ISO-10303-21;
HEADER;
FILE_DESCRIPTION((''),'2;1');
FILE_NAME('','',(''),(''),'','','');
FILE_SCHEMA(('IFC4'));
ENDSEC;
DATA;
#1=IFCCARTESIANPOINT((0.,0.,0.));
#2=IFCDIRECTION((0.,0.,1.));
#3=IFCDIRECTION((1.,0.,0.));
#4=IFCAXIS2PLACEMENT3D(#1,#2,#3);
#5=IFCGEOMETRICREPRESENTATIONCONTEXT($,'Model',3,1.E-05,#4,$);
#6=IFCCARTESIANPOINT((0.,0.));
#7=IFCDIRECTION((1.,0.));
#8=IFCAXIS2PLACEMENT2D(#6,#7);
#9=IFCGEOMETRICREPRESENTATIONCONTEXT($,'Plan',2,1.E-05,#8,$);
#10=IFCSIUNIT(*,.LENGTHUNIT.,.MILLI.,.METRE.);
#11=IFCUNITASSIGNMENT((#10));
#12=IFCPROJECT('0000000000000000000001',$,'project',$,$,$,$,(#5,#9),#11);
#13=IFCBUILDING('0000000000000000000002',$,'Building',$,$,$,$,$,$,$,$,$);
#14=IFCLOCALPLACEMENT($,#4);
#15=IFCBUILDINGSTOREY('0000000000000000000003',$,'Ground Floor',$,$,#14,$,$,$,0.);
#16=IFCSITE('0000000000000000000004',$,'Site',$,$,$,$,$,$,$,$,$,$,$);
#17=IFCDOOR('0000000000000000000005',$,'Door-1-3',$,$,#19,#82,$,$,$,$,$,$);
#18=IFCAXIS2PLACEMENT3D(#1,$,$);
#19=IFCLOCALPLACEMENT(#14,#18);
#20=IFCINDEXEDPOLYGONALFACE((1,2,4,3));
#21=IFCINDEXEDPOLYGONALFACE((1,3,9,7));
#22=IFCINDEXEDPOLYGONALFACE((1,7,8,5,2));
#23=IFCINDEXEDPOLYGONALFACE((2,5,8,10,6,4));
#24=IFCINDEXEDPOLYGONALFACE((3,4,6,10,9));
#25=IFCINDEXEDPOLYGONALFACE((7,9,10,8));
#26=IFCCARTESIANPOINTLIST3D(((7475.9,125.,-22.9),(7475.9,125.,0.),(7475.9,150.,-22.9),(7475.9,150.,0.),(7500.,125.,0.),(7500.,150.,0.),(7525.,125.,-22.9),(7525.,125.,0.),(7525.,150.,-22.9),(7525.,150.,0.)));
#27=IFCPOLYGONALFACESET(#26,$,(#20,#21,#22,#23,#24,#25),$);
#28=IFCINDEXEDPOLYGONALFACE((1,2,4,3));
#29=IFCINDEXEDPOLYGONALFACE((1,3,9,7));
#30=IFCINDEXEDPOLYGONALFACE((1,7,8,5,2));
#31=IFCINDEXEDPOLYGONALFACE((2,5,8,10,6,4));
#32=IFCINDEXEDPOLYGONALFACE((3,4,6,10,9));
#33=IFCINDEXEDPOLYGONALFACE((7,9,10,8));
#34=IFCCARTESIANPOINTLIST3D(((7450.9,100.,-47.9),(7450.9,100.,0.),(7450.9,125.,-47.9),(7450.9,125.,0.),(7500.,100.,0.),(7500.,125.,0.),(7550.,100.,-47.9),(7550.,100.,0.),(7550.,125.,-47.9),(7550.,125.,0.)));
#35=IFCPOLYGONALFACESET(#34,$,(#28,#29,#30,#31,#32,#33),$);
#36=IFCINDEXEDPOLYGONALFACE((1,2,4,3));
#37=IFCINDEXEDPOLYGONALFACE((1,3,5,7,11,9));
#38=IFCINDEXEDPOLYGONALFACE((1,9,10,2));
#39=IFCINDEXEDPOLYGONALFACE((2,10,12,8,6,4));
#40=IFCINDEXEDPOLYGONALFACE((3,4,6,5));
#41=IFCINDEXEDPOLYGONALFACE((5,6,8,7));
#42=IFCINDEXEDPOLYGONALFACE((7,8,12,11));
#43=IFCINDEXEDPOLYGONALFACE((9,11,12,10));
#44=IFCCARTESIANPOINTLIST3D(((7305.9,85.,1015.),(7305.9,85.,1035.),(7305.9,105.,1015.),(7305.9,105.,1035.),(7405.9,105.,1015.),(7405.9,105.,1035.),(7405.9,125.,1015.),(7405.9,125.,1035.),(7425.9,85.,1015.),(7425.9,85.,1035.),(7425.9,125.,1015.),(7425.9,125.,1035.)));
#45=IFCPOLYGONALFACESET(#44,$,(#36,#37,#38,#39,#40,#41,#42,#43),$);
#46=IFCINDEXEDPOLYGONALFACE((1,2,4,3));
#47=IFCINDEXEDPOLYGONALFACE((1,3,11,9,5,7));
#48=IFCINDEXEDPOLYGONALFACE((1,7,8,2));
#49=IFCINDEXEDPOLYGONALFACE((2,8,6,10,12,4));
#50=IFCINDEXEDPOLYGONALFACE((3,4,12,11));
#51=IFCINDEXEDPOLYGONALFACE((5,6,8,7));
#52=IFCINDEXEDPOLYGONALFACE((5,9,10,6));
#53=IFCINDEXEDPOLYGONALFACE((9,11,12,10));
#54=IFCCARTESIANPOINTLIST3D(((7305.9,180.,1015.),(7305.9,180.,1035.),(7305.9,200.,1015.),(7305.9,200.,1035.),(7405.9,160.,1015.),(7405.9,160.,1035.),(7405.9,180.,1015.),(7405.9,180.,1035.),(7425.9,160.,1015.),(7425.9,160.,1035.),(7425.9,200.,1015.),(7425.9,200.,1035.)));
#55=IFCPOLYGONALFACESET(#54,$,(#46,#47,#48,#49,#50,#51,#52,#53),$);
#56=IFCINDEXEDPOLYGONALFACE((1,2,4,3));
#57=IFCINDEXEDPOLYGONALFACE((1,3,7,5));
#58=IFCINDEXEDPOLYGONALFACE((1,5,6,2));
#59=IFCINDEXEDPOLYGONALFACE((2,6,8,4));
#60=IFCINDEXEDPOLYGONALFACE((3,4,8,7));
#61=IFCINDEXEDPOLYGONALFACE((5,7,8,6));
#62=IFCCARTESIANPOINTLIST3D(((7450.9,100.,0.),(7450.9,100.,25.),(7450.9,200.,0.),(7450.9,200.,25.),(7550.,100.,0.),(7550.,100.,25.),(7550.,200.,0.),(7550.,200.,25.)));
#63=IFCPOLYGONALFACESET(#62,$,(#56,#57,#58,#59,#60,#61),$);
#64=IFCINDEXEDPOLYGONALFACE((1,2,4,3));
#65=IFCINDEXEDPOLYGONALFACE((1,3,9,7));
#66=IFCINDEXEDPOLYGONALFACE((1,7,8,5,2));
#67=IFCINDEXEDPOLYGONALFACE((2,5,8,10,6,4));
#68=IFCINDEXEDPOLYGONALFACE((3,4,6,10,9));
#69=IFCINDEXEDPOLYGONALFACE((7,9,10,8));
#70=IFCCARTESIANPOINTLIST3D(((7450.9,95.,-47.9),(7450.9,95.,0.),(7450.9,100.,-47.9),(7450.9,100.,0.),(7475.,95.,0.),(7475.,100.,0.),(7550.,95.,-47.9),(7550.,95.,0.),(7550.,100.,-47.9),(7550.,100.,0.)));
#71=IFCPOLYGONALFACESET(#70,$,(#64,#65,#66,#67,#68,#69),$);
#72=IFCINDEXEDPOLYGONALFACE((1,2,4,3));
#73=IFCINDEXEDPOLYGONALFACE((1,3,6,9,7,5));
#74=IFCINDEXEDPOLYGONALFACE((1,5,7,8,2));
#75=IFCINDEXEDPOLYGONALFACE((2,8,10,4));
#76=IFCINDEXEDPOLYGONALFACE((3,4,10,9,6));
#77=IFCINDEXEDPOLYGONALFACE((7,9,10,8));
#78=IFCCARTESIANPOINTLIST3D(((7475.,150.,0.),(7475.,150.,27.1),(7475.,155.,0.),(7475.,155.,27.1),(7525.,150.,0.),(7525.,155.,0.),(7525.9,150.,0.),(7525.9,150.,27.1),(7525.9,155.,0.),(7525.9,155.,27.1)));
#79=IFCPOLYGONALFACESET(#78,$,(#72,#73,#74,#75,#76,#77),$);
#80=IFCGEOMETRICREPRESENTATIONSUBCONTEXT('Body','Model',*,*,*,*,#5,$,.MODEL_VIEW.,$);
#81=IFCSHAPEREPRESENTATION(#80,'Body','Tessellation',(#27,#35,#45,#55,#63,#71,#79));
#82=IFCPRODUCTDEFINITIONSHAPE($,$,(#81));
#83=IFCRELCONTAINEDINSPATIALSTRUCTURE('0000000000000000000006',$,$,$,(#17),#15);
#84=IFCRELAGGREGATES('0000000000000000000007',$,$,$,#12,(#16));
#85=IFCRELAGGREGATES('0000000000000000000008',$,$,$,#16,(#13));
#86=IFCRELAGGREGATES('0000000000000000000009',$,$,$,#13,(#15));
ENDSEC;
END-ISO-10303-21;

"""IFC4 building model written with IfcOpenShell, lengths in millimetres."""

from ifc_helpers import new_model, si_unit, frame, origin_with_axes, origin_2d_with_axis, place, context, subcontext, project, spatial, line, indexed_curve, outline, extrude, element, save


model = new_model("IFC4")

# Units and contexts
model_context = context("Model", 3, precision=1e-05, world=origin_with_axes())
plan_context = context("Plan", 2, precision=1e-05, world=origin_2d_with_axis())
body_context = subcontext(model_context, "Body", "Model", "MODEL_VIEW")
ifc_project = project(units=[si_unit("LENGTHUNIT", "METRE", prefix="MILLI")], contexts=[model_context, plan_context])

# Site, building, storey
site = spatial("IfcSite", under=ifc_project, Name="Site")
building = spatial("IfcBuilding", under=site, Name="Building")
storey_placement = place(None, origin_with_axes())
storey = spatial("IfcBuildingStorey", under=building, at=storey_placement, Name="Ground Floor", Elevation=0.0)

# Door
door_1_placement = place(storey_placement, frame((7500.0, 100.0, 0.0), z_axis=(0.0, 0.0, 1.0), x_axis=(1.0, 0.0, 0.0)))
element("IfcDoor", 1, at=door_1_placement, inside=storey, Name="Door-1-3", context=body_context, shape_type="SweptSolid", body=[
    extrude(outline(indexed_curve([(0.0, 0.0), (0.0, 2.1), (0.9, 2.1), (0.9, 0.0), (-24.1, 0.0), (-24.1, -22.9), (25.0, -22.9), (25.0, 0.0)], segments=[line(1, 2, 3, 4, 5, 6, 7, 8, 1)])), frame((0.0, 25.0, 0.0), z_axis=(0.0, -1.0, 0.0), x_axis=(1.0, 0.0, 0.0)), (0.0, 0.0, -1.0), 25.0),
    extrude(outline(indexed_curve([(0.0, 0.0), (0.0, 2.1), (0.9, 2.1), (0.9, 0.0), (-49.1, 0.0), (-49.1, -47.9), (50.0, -47.9), (50.0, 0.0)], segments=[line(1, 2, 3, 4, 5, 6, 7, 8, 1)])), frame((0.0, 0.0, 0.0), z_axis=(0.0, -1.0, 0.0), x_axis=(1.0, 0.0, 0.0)), (0.0, 0.0, -1.0), 25.0),
    extrude(outline(indexed_curve([(0.0, 0.0), (-49.1, 0.0), (-49.1, 35.0), (0.0, 35.0)], segments=[line(1, 2, 3, 4, 1)])), frame((25.0, 25.0, 25.0), z_axis=(0.0, 0.0, 1.0), x_axis=(1.0, 0.0, 0.0)), (0.0, 0.0, 1.0), -47.9),
    extrude(outline(indexed_curve([(0.0, 0.0), (0.0, -40.0), (-120.0, -40.0), (-120.0, -20.0), (-20.0, -20.0), (-20.0, 0.0)], segments=[line(1, 2, 3, 4, 5, 6, 1)])), frame((-74.1, 25.0, 1015.0), z_axis=(0.0, 0.0, 1.0), x_axis=(1.0, 0.0, 0.0)), (0.0, 0.0, 1.0), 20.0),
    extrude(outline(indexed_curve([(0.0, 0.0), (0.0, 40.0), (-120.0, 40.0), (-120.0, 20.0), (-20.0, 20.0), (-20.0, 0.0)], segments=[line(1, 2, 3, 4, 5, 6, 1)])), frame((-74.1, 60.0, 1015.0), z_axis=(0.0, 0.0, 1.0), x_axis=(1.0, 0.0, 0.0)), (0.0, 0.0, 1.0), 20.0),
    extrude(outline(indexed_curve([(0.0, 0.0), (-99.1, 0.0), (-99.1, 100.0), (0.0, 100.0)], segments=[line(1, 2, 3, 4, 1)])), frame((50.0, 0.0, 0.0), z_axis=(0.0, 0.0, 1.0), x_axis=(1.0, 0.0, 0.0)), (0.0, 0.0, 1.0), 25.0),
    extrude(outline(indexed_curve([(0.0, 0.0), (0.0, 27.1), (50.9, 27.1), (50.9, 0.0), (-24.1, 0.0), (-24.1, -47.9), (75.0, -47.9), (75.0, 0.0)], segments=[line(1, 2, 3, 4, 5, 6, 7, 8, 1)])), frame((-25.0, -5.0, 0.0), z_axis=(0.0, -1.0, 0.0), x_axis=(1.0, 0.0, 0.0)), (0.0, 0.0, -1.0), 5.0),
    extrude(outline(indexed_curve([(0.0, 0.0), (0.0, 27.1), (50.9, 27.1), (50.9, 0.0), (0.9, 0.0), (0.9, -22.9), (50.0, -22.9), (50.0, 0.0)], segments=[line(1, 2, 3, 4, 5, 6, 7, 8, 1)])), frame((-25.0, 50.0, 0.0), z_axis=(0.0, -1.0, 0.0), x_axis=(1.0, 0.0, 0.0)), (0.0, 0.0, -1.0), 5.0),
])

save(model, "model.ifc")
